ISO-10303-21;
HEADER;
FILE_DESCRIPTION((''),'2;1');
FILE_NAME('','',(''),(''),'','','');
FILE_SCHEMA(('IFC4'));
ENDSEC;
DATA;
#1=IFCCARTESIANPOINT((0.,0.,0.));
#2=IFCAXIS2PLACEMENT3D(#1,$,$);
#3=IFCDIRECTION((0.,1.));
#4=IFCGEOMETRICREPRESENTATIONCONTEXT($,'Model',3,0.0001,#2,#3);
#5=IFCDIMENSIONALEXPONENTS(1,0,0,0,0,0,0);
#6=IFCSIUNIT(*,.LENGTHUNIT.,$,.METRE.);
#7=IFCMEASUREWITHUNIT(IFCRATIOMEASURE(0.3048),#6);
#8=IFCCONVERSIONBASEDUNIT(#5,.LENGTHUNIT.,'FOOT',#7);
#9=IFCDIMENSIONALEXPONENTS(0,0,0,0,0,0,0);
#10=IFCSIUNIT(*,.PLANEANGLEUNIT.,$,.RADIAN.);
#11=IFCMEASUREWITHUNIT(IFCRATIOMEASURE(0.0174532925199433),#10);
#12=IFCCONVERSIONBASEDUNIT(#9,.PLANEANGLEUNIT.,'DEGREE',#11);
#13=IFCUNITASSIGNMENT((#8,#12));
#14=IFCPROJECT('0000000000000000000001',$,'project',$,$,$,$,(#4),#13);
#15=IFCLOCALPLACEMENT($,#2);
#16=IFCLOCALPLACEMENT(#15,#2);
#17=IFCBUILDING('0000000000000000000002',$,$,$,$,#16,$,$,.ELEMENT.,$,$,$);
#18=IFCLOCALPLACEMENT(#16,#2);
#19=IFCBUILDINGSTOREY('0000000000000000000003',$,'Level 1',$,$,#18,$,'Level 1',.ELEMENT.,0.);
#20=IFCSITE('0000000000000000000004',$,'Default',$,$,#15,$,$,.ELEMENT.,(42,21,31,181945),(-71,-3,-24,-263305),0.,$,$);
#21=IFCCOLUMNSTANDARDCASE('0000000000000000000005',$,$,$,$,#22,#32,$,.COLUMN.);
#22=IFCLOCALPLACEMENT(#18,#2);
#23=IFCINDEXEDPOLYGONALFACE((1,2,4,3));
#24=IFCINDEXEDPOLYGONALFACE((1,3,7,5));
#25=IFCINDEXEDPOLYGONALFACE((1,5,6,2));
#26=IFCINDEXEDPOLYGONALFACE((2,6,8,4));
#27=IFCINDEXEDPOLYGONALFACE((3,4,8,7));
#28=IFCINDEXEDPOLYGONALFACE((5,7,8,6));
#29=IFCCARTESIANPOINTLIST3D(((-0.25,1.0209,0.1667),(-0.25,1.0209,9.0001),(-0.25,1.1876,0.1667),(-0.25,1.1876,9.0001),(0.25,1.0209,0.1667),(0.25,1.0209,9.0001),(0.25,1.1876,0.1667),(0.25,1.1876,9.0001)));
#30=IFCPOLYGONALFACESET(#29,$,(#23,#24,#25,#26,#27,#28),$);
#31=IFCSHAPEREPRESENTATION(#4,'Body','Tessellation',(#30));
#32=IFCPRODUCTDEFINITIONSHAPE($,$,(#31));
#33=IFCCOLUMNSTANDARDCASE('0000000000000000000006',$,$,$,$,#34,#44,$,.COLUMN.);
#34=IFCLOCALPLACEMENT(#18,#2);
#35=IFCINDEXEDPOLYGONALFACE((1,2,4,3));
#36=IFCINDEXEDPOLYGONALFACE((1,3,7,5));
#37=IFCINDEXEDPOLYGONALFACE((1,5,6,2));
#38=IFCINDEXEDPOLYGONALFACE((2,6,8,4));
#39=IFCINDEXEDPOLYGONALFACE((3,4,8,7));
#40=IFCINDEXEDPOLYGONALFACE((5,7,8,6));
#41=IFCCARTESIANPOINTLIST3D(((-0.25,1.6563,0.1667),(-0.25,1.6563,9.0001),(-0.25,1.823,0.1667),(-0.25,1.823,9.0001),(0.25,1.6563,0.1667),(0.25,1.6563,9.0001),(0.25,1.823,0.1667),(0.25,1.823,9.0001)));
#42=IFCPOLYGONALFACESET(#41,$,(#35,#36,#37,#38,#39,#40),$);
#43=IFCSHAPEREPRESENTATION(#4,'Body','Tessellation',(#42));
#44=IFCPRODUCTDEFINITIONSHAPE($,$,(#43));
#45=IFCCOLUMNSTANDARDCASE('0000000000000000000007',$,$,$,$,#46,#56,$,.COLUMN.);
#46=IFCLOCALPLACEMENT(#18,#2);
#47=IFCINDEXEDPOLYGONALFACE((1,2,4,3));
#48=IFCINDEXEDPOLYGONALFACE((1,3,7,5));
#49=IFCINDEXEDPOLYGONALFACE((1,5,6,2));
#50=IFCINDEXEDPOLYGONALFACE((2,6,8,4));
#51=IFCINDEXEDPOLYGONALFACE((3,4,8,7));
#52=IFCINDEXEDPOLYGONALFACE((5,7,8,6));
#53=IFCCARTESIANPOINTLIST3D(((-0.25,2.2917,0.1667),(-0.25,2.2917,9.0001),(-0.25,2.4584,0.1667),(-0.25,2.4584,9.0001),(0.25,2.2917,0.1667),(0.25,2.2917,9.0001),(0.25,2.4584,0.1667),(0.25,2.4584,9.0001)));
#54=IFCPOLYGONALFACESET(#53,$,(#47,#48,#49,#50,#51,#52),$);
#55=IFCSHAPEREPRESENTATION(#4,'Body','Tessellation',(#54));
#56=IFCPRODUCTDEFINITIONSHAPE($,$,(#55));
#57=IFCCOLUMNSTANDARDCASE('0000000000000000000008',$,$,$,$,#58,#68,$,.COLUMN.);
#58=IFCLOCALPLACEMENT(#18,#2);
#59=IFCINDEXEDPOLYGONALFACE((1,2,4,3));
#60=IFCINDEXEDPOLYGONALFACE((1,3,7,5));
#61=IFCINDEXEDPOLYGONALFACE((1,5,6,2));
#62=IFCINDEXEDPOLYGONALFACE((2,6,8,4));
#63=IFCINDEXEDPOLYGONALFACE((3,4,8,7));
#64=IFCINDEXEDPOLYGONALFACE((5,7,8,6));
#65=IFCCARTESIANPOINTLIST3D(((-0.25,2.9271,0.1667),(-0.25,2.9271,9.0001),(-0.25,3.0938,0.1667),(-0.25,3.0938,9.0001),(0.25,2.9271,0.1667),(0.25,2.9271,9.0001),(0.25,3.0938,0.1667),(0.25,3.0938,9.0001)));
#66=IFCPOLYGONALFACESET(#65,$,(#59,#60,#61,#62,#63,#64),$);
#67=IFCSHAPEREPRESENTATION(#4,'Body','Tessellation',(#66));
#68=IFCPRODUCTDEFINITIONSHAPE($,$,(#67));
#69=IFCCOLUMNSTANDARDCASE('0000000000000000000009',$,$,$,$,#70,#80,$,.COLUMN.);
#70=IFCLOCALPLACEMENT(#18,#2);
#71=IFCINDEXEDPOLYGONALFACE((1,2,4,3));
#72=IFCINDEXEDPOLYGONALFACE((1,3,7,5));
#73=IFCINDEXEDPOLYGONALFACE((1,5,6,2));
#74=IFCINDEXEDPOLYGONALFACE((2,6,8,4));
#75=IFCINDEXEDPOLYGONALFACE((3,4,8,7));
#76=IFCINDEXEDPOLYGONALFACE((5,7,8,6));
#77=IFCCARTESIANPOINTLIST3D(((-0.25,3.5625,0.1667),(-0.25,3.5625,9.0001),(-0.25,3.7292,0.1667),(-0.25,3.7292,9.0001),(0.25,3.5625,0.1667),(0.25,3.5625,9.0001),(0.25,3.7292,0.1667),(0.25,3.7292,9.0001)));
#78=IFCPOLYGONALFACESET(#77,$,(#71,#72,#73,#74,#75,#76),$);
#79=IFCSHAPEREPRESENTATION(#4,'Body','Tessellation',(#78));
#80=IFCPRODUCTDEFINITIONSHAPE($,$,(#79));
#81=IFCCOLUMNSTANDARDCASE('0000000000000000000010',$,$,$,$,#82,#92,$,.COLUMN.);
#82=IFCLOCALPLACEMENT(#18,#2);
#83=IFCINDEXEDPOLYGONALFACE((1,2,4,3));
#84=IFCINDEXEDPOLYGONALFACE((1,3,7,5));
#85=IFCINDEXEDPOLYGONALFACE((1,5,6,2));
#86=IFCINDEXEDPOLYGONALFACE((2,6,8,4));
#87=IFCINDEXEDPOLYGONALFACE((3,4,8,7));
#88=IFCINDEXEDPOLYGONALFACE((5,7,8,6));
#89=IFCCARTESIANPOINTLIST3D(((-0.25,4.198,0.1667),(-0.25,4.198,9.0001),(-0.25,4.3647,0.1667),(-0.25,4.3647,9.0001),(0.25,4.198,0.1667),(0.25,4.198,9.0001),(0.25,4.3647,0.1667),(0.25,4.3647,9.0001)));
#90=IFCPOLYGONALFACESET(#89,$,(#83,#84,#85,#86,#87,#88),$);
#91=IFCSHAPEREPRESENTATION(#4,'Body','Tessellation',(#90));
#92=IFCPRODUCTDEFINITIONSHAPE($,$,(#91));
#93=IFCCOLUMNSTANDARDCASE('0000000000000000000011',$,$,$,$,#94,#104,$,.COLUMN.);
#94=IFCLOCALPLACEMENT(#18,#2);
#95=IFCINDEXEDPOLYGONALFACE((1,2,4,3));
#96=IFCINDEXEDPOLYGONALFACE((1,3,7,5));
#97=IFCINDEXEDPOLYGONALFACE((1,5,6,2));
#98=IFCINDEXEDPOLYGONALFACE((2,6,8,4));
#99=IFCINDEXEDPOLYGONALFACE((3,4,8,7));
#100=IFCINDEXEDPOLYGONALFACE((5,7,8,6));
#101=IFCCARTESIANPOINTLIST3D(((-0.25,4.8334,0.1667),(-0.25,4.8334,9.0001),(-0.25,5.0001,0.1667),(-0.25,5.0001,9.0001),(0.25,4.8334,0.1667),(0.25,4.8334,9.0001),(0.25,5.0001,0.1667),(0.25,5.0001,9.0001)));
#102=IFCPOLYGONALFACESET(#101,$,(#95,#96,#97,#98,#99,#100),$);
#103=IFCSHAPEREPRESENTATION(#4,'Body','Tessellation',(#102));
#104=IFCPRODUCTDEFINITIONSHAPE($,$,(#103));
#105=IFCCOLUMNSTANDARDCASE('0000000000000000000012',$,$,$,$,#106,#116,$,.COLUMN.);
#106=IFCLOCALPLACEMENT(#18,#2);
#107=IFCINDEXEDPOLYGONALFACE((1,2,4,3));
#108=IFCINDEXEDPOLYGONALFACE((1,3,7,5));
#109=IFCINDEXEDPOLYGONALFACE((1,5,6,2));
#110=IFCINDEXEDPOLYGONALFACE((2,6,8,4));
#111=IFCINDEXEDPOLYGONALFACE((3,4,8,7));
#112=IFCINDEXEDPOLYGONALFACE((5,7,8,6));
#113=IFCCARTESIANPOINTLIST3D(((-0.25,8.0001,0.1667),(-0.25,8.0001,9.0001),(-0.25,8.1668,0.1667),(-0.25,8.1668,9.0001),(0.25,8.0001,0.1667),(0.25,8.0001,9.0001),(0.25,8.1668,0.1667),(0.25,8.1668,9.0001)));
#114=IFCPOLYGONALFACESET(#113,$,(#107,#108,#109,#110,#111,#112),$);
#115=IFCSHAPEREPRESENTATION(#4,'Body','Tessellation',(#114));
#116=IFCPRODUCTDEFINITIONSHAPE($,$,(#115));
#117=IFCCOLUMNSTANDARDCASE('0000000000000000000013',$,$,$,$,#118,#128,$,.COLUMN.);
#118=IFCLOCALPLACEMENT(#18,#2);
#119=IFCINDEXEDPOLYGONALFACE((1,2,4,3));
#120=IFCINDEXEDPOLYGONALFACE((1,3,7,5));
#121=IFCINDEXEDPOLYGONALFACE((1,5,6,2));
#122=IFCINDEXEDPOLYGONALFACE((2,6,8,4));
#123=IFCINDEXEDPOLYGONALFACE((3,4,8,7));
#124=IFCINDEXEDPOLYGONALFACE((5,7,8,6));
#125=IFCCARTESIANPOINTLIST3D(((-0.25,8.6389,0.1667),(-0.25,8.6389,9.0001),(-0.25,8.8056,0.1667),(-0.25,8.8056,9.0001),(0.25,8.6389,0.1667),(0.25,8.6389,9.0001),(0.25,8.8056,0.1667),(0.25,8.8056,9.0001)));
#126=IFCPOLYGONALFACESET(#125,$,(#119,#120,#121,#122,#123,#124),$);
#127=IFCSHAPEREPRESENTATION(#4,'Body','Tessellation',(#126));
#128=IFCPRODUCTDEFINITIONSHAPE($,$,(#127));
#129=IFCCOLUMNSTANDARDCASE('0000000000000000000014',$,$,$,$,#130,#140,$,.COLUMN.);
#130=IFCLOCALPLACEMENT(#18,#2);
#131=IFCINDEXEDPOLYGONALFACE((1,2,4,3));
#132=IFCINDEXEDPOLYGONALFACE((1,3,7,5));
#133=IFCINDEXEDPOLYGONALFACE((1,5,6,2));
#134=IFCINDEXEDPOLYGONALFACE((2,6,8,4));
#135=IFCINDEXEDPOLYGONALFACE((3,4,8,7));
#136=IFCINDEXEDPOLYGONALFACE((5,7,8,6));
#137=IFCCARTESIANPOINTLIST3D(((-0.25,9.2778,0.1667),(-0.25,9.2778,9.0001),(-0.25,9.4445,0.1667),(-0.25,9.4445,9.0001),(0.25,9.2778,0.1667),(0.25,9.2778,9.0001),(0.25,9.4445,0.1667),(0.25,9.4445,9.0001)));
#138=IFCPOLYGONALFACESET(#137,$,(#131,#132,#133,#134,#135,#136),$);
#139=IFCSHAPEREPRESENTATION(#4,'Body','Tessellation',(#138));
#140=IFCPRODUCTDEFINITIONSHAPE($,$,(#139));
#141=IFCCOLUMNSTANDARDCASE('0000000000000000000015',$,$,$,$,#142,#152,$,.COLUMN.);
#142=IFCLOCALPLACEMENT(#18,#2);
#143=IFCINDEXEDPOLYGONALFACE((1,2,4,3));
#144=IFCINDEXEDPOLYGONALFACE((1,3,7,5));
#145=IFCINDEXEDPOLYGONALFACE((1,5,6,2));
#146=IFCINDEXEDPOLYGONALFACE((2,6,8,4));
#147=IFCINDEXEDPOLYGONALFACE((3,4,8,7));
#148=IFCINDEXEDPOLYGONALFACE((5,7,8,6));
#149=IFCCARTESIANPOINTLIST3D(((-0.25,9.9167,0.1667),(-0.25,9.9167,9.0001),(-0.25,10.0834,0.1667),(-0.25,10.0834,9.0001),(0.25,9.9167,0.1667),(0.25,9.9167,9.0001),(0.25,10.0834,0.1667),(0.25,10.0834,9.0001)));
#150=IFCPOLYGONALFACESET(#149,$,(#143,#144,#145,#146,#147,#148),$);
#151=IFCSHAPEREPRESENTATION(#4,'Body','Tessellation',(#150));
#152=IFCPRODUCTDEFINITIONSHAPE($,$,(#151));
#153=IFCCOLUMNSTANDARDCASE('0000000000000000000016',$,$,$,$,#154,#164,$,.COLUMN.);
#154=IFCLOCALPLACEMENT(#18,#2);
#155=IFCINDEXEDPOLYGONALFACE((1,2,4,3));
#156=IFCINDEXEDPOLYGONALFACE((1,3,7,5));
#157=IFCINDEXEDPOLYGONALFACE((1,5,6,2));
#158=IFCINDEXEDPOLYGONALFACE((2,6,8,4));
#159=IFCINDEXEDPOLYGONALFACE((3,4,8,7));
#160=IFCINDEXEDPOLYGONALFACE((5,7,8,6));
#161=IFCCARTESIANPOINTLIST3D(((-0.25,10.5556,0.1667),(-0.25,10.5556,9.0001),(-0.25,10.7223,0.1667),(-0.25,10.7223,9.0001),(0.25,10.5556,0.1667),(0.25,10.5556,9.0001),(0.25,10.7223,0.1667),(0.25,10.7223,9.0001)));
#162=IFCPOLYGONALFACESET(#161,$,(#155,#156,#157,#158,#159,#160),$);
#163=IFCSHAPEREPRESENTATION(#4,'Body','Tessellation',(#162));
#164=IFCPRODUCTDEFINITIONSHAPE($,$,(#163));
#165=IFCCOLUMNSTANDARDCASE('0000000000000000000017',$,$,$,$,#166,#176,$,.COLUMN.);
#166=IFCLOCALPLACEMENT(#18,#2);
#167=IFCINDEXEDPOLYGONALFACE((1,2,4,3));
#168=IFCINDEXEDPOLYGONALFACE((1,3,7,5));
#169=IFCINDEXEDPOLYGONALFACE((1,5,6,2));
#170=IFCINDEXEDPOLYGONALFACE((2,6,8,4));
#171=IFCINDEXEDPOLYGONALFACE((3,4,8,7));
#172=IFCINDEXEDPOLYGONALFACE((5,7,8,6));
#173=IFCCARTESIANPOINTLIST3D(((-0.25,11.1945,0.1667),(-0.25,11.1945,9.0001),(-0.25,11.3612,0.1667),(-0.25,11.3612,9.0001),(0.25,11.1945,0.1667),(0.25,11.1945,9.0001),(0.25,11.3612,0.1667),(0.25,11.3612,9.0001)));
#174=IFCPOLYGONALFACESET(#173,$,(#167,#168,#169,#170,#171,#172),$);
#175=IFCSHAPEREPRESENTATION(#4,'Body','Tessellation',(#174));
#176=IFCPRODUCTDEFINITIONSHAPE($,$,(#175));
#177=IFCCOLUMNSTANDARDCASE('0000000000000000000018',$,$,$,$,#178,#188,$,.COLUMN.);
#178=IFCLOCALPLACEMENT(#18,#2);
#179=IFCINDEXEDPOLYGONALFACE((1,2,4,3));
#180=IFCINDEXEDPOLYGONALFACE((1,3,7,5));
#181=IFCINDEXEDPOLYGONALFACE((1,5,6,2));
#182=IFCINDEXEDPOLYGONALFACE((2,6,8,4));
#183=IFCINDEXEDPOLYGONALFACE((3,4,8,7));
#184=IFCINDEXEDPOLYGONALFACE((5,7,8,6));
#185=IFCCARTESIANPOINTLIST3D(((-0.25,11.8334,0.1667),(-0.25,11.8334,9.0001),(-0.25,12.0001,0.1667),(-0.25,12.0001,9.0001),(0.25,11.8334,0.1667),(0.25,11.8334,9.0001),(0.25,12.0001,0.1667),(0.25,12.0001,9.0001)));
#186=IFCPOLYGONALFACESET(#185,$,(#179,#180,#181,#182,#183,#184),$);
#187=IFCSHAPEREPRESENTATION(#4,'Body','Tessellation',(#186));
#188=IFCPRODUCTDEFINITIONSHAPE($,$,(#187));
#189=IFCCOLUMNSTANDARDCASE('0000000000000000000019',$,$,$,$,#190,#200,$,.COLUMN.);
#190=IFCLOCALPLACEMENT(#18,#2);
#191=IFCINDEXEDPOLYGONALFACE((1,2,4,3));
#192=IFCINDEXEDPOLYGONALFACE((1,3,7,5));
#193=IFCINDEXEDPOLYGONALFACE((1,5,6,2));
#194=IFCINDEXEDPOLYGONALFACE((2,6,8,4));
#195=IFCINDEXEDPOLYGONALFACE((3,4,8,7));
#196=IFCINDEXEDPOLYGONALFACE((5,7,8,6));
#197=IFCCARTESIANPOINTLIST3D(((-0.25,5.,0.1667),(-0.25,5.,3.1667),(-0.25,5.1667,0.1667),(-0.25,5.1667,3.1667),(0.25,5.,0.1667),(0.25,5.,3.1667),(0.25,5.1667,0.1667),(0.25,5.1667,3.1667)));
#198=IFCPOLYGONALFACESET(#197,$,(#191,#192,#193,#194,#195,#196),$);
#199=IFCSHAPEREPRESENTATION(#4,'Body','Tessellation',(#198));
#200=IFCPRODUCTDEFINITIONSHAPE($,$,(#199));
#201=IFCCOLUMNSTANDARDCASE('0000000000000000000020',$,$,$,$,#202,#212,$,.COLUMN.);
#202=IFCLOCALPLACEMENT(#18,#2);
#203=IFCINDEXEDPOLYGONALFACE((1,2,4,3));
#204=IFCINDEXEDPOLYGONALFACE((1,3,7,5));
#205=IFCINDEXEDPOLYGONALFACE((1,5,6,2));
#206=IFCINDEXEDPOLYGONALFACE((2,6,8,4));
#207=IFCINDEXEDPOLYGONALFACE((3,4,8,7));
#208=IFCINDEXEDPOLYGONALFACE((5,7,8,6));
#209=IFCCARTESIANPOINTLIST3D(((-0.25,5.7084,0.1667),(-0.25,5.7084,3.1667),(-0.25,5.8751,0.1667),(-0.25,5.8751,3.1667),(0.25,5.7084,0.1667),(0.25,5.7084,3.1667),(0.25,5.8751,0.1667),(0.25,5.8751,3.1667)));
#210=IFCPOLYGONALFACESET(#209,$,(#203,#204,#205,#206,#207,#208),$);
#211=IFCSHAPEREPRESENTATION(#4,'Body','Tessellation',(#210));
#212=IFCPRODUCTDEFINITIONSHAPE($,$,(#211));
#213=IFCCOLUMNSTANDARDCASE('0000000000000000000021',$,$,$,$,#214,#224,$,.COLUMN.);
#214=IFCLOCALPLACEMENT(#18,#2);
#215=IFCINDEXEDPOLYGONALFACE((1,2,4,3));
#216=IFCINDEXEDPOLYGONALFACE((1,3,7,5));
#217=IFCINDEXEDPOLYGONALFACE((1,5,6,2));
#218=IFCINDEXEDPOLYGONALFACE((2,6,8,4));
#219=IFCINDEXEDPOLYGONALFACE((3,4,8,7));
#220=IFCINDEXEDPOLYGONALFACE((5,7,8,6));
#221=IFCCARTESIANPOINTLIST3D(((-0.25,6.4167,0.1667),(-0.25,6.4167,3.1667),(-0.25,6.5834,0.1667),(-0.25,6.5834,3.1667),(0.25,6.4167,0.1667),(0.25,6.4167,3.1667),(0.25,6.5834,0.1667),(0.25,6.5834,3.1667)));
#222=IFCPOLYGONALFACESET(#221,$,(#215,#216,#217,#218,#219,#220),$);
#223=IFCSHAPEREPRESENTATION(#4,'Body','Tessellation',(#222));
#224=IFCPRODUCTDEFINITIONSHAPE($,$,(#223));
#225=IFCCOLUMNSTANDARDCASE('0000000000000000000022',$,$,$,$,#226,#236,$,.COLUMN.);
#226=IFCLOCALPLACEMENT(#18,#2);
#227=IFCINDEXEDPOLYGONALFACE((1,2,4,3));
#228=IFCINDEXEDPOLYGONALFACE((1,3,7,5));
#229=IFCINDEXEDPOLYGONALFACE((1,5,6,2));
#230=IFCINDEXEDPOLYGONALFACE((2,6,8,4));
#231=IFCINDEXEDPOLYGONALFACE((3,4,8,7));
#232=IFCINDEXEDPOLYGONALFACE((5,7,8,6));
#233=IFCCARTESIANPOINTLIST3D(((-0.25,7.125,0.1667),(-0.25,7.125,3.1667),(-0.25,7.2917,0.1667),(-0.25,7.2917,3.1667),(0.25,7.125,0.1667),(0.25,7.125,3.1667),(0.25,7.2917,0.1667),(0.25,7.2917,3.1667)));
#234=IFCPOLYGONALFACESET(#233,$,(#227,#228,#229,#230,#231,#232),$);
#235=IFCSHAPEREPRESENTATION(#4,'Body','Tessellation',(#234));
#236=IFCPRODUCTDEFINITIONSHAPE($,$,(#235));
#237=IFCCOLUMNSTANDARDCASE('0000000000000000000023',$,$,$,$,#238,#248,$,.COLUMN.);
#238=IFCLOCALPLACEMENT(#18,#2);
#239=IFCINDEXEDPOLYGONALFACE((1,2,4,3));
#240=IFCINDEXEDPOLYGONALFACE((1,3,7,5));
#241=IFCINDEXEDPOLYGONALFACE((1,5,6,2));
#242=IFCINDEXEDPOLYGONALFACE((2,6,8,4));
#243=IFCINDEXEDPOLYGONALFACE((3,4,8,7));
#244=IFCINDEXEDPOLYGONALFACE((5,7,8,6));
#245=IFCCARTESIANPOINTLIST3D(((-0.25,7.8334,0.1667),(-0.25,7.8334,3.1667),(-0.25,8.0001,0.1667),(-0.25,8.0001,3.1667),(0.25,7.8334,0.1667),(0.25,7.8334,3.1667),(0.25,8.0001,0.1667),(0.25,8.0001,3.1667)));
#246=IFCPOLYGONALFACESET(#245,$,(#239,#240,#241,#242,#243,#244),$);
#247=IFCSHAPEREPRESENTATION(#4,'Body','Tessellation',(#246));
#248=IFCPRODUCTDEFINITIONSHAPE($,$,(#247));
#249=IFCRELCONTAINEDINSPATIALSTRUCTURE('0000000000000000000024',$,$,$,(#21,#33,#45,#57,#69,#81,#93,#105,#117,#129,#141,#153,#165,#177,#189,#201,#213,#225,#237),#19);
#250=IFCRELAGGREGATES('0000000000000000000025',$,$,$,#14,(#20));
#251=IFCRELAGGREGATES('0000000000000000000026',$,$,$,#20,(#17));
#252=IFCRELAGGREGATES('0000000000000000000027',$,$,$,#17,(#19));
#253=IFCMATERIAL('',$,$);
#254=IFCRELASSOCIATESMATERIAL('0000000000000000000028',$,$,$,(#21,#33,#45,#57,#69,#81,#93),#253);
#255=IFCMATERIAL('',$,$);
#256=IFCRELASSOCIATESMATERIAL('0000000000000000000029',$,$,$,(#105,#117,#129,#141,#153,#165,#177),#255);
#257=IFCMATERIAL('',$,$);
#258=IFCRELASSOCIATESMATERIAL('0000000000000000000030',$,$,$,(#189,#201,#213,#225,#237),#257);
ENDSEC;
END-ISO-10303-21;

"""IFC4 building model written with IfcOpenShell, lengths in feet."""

from ifc_helpers import new_model, entity, si_unit, converted_unit, direction, frame, origin, place, context, project, spatial, rectangle, extrude, material, element, save


model = new_model("IFC4")

# Units and contexts
model_context = context("Model", 3, precision=0.0001, world=origin(), true_north=direction((0.0, 1.0)))
ifc_project = project(units=[converted_unit("LENGTHUNIT", "FOOT", entity("IfcRatioMeasure", 0.3048), si_unit("LENGTHUNIT", "METRE"), dimensions=[1, 0, 0, 0, 0, 0, 0]), converted_unit("PLANEANGLEUNIT", "DEGREE", entity("IfcRatioMeasure", 0.0174532925199433), si_unit("PLANEANGLEUNIT", "RADIAN"), dimensions=[0, 0, 0, 0, 0, 0, 0])], contexts=[model_context])

# Site, building, storey
site_placement = place(None, origin())
site = spatial("IfcSite", under=ifc_project, at=site_placement, Name="Default", CompositionType="ELEMENT", RefLatitude=(42, 21, 31, 181945), RefLongitude=(-71, -3, -24, -263305), RefElevation=0.0)
building_placement = place(site_placement, origin())
building = spatial("IfcBuilding", under=site, at=building_placement, CompositionType="ELEMENT")
storey_placement = place(building_placement, origin())
storey = spatial("IfcBuildingStorey", under=building, at=storey_placement, Name="Level 1", LongName="Level 1", CompositionType="ELEMENT", Elevation=0.0)

# Columns
ifc_material_1 = material(Name="")
placement_1 = place(storey_placement, frame((0.0, -0.25, 0.0), z_axis=(0.0, 0.0, 1.0), x_axis=(0.0, 1.0, 0.0)))
for number, where, z_axis, x_axis in (
    (1, (1.3542, 0.0, 0.1667), (0.0, 0.0, 1.0), (1.0, 0.0, 0.0)),
    (2, (1.9896, 0.0, 0.1667), (0.0, 0.0, 1.0), (1.0, 0.0, 0.0)),
    (3, (2.625, 0.0, 0.1667), (0.0, 0.0, 1.0), (1.0, 0.0, 0.0)),
    (4, (3.2604, 0.0, 0.1667), (0.0, 0.0, 1.0), (1.0, 0.0, 0.0)),
    (5, (3.8958, 0.0, 0.1667), (0.0, 0.0, 1.0), (1.0, 0.0, 0.0)),
    (6, (4.5313, 0.0, 0.1667), (0.0, 0.0, 1.0), (1.0, 0.0, 0.0)),
    (7, (5.1667, 0.0, 0.1667), (0.0, 0.0, 1.0), (1.0, 0.0, 0.0)),
):
    element("IfcColumnStandardCase", number, at=place(placement_1, frame(where, z_axis=z_axis, x_axis=x_axis)), inside=storey, material=ifc_material_1, PredefinedType="COLUMN", context=model_context, shape_type="SweptSolid", body=[
        extrude(rectangle(XDim=0.1667, YDim=0.5), origin(), (0.0, 0.0, 1.0), 8.8334),
    ])
ifc_material_2 = material(Name="")
for number, where, z_axis, x_axis in (
    (8, (8.3334, 0.0, 0.1667), (0.0, 0.0, 1.0), (1.0, 0.0, 0.0)),
    (9, (8.9722, 0.0, 0.1667), (0.0, 0.0, 1.0), (1.0, 0.0, 0.0)),
    (10, (9.6111, 0.0, 0.1667), (0.0, 0.0, 1.0), (1.0, 0.0, 0.0)),
    (11, (10.25, 0.0, 0.1667), (0.0, 0.0, 1.0), (1.0, 0.0, 0.0)),
    (12, (10.8889, 0.0, 0.1667), (0.0, 0.0, 1.0), (1.0, 0.0, 0.0)),
    (13, (11.5278, 0.0, 0.1667), (0.0, 0.0, 1.0), (1.0, 0.0, 0.0)),
    (14, (12.1667, 0.0, 0.1667), (0.0, 0.0, 1.0), (1.0, 0.0, 0.0)),
):
    element("IfcColumnStandardCase", number, at=place(placement_1, frame(where, z_axis=z_axis, x_axis=x_axis)), inside=storey, material=ifc_material_2, PredefinedType="COLUMN", context=model_context, shape_type="SweptSolid", body=[
        extrude(rectangle(XDim=0.1667, YDim=0.5), origin(), (0.0, 0.0, 1.0), 8.8334),
    ])
ifc_material_3 = material(Name="")
for number, where, z_axis, x_axis in (
    (15, (5.3333, 0.0, 0.1667), (0.0, 0.0, 1.0), (1.0, 0.0, 0.0)),
    (16, (6.0417, 0.0, 0.1667), (0.0, 0.0, 1.0), (1.0, 0.0, 0.0)),
    (17, (6.75, 0.0, 0.1667), (0.0, 0.0, 1.0), (1.0, 0.0, 0.0)),
    (18, (7.4583, 0.0, 0.1667), (0.0, 0.0, 1.0), (1.0, 0.0, 0.0)),
    (19, (8.1667, 0.0, 0.1667), (0.0, 0.0, 1.0), (1.0, 0.0, 0.0)),
):
    element("IfcColumnStandardCase", number, at=place(placement_1, frame(where, z_axis=z_axis, x_axis=x_axis)), inside=storey, material=ifc_material_3, PredefinedType="COLUMN", context=model_context, shape_type="SweptSolid", body=[
        extrude(rectangle(XDim=0.1667, YDim=0.5), origin(), (0.0, 0.0, 1.0), 3.0),
    ])

save(model, "model.ifc")
